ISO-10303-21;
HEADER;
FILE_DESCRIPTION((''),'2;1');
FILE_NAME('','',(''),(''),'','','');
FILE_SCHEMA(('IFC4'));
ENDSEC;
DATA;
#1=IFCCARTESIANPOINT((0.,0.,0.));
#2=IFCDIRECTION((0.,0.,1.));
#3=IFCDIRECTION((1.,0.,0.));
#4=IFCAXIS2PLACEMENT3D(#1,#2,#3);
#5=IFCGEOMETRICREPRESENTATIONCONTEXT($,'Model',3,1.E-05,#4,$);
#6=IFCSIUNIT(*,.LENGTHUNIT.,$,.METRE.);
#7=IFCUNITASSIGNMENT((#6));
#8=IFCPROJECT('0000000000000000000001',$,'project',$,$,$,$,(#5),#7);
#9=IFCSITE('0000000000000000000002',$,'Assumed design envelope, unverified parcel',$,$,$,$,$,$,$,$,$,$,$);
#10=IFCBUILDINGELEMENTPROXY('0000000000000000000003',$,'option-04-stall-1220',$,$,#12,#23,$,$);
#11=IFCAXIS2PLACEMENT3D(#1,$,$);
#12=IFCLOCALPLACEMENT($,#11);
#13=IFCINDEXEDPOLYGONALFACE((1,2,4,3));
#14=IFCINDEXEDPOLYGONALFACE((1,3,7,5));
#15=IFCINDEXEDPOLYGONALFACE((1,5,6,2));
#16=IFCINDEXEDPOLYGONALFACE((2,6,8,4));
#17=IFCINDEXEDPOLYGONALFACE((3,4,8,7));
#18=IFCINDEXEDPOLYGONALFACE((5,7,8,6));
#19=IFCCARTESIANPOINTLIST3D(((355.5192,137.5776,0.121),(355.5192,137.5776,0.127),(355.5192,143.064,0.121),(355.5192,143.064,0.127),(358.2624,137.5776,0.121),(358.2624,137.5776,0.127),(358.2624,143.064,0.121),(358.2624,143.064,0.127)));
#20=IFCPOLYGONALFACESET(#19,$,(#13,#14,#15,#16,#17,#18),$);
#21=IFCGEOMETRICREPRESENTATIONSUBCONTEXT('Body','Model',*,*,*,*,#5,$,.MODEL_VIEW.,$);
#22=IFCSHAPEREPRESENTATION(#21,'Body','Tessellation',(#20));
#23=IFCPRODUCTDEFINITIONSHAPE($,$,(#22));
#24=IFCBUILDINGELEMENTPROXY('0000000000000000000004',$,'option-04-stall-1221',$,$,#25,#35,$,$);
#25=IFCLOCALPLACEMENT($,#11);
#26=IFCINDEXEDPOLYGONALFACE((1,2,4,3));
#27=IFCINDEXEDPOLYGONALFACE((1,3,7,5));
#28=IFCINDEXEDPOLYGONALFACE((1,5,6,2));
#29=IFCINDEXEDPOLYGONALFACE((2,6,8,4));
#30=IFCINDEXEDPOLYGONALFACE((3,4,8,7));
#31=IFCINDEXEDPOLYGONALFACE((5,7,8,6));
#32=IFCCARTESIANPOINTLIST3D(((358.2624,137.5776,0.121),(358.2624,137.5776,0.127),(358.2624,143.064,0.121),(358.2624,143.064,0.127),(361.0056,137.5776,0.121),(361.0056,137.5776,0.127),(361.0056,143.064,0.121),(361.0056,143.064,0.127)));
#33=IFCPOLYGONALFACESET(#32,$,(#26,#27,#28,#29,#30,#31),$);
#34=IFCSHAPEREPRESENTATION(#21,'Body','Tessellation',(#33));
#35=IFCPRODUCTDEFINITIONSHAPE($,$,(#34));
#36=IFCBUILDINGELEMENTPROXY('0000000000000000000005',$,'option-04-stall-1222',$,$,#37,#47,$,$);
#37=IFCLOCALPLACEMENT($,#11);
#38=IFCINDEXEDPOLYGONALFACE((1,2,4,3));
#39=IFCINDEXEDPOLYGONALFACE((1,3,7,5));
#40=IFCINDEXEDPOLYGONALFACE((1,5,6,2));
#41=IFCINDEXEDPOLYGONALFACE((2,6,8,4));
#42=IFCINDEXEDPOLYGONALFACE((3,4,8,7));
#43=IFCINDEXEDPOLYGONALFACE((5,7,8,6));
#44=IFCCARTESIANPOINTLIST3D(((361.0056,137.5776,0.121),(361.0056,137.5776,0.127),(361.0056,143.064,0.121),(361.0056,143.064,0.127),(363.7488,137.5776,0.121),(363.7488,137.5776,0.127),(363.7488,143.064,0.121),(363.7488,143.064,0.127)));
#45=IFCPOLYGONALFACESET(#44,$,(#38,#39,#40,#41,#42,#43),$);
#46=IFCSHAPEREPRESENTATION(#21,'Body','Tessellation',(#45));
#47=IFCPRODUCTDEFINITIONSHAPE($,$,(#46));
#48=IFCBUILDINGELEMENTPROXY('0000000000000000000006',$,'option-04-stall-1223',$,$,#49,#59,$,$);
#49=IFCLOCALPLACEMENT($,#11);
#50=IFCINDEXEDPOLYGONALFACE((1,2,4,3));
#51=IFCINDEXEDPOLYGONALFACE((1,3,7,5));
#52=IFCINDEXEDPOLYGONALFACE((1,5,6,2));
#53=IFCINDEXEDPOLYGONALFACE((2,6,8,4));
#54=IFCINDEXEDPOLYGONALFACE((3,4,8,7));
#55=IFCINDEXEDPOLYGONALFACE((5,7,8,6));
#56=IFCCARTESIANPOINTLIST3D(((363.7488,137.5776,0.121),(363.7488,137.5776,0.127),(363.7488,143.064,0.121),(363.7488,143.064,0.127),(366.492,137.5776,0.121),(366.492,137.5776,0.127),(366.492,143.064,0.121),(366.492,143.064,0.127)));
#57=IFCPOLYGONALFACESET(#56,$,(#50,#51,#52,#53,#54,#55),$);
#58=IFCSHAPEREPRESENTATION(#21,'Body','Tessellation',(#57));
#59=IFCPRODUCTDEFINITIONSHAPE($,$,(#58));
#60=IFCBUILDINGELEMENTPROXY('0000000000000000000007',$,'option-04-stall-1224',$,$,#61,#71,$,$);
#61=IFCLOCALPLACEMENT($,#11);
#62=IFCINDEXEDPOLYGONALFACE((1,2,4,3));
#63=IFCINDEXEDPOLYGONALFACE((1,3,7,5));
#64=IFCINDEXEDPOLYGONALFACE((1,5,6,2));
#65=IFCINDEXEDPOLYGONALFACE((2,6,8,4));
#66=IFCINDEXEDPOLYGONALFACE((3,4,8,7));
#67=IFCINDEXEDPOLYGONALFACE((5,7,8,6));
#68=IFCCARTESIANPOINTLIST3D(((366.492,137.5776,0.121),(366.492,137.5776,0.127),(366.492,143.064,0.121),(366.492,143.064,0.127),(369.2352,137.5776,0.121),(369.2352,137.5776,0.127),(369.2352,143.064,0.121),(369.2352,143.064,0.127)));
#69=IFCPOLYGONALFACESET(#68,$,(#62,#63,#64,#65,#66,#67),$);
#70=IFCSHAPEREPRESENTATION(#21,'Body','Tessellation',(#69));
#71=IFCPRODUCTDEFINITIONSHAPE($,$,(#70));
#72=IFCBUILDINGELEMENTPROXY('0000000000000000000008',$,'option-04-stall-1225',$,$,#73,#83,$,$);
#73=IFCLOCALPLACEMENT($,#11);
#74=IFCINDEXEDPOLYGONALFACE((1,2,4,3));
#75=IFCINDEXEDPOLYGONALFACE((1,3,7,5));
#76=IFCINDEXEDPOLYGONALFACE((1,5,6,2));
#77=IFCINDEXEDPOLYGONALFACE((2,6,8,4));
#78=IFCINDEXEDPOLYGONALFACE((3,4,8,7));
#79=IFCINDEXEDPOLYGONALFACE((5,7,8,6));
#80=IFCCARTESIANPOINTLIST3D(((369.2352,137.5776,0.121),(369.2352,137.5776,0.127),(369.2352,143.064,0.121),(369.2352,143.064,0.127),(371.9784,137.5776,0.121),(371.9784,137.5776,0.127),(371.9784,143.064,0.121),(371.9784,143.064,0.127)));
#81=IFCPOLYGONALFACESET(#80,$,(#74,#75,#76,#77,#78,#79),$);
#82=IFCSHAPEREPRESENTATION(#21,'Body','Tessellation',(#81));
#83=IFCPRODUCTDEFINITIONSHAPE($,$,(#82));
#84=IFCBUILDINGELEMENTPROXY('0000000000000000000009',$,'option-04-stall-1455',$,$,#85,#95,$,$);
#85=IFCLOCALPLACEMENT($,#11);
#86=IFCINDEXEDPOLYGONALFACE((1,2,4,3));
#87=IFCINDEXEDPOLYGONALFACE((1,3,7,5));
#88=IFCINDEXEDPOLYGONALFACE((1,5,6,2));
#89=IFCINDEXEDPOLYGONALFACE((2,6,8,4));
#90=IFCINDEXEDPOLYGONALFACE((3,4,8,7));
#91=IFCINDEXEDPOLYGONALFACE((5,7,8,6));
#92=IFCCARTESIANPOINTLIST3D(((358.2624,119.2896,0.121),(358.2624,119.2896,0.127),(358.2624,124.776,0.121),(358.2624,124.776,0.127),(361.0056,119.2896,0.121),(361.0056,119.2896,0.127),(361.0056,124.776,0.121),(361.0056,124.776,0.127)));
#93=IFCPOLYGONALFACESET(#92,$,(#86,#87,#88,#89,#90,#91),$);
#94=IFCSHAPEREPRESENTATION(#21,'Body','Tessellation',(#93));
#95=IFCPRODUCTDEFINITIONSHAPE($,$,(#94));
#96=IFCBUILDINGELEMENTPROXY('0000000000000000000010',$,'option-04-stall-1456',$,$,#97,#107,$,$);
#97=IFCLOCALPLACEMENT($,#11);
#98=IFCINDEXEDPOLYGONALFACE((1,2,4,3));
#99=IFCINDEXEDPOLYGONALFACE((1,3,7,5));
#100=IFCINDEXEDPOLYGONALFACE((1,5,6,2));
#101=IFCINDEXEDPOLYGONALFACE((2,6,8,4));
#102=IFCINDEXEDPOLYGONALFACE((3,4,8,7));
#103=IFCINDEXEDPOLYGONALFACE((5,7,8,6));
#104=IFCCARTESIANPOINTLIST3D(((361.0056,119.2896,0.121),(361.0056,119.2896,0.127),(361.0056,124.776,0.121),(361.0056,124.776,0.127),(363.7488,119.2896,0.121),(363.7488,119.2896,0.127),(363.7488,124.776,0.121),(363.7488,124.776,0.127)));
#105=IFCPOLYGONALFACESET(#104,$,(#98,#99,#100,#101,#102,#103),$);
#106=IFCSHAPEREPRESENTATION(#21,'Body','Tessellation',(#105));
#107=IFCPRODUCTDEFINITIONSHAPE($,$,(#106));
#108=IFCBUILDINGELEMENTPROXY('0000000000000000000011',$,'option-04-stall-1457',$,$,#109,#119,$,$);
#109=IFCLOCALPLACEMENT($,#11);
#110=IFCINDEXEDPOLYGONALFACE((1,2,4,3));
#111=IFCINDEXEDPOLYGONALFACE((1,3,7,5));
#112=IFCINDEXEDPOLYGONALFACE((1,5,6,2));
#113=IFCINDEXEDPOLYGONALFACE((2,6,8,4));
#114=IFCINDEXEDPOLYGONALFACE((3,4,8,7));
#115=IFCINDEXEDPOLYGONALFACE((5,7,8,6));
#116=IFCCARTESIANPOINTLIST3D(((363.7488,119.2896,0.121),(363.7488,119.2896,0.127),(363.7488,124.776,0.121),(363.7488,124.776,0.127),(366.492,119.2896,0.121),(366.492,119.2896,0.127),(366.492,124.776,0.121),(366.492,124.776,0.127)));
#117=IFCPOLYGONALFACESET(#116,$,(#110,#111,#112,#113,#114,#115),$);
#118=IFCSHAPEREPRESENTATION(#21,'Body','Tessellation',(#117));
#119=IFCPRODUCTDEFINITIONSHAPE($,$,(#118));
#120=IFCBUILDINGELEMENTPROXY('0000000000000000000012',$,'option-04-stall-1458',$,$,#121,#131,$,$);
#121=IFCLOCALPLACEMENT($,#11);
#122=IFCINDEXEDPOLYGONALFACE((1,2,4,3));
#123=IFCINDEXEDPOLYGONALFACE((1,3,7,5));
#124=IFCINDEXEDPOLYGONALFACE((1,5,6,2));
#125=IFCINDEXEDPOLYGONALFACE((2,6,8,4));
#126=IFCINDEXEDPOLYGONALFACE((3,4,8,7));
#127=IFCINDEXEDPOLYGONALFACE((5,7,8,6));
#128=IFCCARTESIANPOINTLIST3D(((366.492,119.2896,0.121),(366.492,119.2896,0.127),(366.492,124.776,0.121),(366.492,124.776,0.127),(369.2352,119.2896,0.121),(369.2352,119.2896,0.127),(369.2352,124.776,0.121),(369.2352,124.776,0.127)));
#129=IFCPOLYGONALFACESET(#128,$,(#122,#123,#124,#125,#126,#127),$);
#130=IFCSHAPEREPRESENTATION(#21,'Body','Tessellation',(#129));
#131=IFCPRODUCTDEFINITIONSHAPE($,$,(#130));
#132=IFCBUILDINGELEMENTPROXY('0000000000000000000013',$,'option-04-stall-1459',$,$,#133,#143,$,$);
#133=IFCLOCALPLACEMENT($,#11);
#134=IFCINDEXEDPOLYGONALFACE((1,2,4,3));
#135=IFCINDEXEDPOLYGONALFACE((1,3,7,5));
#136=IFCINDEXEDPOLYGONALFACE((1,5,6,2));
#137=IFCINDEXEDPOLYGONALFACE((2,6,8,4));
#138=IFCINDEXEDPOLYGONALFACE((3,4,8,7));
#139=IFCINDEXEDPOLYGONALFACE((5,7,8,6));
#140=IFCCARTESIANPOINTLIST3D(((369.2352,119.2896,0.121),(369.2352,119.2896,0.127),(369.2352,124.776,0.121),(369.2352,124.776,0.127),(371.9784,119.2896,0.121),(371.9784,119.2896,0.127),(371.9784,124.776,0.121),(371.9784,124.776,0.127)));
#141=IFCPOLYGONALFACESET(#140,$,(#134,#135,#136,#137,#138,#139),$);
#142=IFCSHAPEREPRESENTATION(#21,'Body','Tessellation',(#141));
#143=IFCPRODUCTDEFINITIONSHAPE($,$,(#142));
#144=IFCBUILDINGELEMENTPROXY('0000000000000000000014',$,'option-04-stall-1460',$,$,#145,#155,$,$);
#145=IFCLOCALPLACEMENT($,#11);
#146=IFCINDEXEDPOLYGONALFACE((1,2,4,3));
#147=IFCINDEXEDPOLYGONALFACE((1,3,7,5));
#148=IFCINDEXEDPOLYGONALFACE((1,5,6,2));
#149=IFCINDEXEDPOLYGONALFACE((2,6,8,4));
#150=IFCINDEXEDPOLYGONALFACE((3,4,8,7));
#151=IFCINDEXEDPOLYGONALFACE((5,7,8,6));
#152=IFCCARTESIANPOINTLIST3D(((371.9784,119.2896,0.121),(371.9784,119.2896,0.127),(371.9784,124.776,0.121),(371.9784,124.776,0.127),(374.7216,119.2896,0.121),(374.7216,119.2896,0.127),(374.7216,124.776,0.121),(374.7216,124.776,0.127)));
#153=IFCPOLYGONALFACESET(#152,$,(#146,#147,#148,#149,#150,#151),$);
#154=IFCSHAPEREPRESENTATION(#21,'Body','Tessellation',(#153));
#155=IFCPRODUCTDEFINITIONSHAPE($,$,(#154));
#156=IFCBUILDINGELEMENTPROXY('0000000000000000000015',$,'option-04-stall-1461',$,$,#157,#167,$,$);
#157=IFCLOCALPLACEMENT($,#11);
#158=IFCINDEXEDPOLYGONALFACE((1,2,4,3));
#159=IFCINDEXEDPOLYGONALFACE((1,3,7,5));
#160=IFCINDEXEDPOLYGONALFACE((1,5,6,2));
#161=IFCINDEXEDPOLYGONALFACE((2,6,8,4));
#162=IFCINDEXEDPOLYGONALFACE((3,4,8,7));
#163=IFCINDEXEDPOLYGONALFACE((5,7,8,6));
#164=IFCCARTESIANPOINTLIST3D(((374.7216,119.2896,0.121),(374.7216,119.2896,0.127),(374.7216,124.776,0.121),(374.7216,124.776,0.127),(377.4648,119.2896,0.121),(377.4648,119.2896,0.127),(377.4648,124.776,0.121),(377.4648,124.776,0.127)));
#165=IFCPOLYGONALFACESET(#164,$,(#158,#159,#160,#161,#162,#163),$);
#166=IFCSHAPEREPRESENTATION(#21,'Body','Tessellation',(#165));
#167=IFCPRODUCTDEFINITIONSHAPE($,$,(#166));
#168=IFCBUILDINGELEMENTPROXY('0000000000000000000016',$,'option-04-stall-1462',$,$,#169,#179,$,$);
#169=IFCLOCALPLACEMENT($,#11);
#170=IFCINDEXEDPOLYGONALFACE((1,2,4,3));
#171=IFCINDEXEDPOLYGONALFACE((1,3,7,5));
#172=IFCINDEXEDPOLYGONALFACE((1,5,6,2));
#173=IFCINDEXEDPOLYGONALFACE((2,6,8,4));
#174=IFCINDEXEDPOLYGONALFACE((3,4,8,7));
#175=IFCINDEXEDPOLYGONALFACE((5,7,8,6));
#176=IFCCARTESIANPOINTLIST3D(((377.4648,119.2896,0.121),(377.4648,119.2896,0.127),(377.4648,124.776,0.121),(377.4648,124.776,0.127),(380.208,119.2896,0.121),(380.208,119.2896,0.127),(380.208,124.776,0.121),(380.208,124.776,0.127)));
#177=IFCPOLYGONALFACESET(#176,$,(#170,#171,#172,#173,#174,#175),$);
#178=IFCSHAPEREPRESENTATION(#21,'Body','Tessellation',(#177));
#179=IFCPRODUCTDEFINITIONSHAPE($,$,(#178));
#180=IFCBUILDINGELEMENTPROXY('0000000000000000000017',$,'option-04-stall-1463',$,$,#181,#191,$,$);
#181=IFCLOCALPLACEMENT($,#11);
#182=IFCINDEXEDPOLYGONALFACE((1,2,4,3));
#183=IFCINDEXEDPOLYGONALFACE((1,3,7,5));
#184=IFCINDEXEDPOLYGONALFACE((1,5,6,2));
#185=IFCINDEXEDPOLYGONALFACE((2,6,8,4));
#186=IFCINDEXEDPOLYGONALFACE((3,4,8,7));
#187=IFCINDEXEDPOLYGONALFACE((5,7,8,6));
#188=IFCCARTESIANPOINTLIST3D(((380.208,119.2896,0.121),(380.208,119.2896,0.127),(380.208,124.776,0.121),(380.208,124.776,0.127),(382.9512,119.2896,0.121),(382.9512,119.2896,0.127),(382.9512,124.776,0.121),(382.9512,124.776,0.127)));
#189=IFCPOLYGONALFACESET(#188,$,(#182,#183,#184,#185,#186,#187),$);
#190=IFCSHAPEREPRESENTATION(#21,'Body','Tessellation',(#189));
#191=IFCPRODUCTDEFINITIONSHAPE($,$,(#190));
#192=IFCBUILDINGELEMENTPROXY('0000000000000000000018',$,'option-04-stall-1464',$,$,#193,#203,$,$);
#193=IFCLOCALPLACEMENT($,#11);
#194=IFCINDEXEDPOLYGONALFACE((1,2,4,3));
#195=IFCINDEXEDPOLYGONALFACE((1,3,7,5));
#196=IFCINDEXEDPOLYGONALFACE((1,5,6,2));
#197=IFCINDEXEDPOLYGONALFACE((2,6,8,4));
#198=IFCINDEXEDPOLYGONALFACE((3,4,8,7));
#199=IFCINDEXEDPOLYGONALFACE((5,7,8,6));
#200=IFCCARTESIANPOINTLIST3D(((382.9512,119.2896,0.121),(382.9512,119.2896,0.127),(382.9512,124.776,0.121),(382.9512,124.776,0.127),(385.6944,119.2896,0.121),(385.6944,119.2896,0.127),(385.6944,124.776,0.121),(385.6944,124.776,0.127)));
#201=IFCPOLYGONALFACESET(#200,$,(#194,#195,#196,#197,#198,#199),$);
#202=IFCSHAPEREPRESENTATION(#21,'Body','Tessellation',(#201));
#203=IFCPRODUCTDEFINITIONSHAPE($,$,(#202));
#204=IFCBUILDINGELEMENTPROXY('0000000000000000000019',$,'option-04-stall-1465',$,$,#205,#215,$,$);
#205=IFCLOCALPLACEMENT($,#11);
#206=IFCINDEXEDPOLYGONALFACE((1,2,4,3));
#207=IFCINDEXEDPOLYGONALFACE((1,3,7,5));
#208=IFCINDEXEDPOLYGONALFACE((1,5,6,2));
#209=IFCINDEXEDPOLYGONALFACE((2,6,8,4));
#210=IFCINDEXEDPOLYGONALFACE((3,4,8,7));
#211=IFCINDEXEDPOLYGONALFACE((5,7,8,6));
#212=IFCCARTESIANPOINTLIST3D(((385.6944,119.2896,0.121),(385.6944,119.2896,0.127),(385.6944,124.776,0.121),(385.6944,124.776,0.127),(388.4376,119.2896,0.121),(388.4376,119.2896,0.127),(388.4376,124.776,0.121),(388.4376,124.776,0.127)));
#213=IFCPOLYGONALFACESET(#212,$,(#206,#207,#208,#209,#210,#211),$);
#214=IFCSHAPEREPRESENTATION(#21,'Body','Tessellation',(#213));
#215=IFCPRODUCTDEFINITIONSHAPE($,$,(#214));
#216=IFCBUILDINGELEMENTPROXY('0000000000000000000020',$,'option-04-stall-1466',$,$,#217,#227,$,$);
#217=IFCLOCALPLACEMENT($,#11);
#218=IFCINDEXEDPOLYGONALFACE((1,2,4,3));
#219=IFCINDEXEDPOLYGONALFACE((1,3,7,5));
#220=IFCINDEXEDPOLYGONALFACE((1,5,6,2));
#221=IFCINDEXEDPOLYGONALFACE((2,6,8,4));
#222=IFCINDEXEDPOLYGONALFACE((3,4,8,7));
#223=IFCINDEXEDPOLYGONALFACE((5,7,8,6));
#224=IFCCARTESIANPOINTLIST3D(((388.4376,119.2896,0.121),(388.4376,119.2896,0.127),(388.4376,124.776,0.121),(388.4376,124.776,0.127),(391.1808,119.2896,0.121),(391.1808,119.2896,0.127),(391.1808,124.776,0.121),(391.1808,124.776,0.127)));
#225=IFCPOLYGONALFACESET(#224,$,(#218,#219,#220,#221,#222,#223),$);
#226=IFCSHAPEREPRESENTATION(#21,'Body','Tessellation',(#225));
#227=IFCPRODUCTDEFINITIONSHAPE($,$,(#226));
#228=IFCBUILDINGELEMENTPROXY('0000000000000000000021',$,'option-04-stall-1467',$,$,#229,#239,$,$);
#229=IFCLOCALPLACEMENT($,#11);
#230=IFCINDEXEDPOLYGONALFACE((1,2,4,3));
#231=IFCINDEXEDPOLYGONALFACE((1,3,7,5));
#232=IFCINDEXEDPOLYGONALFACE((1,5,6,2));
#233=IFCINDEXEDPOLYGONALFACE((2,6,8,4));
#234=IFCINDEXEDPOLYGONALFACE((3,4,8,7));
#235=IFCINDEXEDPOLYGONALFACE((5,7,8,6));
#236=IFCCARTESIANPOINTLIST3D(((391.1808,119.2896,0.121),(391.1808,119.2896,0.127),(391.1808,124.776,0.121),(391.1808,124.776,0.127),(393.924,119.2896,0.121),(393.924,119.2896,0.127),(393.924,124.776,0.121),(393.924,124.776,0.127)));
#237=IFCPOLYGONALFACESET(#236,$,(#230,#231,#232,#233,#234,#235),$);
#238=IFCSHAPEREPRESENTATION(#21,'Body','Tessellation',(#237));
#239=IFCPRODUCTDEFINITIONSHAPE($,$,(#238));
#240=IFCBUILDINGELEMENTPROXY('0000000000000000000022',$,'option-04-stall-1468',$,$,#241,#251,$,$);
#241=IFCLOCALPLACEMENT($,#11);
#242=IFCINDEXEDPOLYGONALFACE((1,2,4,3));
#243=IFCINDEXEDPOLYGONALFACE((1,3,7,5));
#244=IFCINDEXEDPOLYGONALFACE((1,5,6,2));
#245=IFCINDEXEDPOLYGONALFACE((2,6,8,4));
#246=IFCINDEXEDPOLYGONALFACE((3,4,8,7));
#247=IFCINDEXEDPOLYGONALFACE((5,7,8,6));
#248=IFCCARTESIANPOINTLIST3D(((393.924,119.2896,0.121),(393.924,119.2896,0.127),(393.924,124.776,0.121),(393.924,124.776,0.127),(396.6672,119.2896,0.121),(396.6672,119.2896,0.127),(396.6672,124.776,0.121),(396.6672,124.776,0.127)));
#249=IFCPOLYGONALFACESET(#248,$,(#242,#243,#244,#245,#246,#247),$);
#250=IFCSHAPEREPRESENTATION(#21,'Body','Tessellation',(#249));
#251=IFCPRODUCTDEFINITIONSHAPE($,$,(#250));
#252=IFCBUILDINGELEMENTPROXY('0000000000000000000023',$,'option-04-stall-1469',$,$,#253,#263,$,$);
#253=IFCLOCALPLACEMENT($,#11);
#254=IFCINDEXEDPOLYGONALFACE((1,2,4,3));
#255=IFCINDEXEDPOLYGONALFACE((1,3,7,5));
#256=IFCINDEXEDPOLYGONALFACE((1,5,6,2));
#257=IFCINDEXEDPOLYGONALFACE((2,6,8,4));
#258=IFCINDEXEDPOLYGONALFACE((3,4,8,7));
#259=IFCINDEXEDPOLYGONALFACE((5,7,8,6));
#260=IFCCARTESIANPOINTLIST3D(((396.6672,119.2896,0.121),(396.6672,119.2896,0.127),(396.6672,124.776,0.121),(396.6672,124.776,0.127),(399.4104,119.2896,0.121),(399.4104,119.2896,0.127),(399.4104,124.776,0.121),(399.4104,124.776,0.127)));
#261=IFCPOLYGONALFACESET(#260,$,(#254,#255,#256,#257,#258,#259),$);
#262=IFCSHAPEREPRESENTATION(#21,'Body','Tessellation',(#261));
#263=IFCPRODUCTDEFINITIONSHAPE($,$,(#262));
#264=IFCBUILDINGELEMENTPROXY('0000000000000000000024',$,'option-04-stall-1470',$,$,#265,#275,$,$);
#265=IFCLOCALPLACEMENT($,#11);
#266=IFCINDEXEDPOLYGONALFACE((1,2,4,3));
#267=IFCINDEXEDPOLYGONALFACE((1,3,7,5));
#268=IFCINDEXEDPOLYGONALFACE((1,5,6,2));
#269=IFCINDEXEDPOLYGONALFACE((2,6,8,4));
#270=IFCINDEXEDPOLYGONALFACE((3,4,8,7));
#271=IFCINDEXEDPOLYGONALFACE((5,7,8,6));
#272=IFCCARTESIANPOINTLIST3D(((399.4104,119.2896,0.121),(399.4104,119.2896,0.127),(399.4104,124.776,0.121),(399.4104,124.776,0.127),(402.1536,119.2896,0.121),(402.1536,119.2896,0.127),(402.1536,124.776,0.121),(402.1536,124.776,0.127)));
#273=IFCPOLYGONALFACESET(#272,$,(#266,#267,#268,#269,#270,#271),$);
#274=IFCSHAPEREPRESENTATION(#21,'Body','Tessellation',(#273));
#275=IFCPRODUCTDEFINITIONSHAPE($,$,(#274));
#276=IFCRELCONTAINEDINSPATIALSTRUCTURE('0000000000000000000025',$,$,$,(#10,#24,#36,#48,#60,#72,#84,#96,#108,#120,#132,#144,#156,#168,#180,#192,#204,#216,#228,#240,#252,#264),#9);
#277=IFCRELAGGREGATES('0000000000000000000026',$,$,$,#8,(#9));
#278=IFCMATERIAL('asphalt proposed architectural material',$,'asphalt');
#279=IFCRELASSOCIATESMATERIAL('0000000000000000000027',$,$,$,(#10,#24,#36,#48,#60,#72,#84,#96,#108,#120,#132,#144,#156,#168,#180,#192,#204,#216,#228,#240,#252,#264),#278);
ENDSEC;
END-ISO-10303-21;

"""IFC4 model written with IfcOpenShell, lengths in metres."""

from ifc_helpers import new_model, si_unit, frame, origin_with_axes, place, context, subcontext, project, spatial, rectangle, extrude, material, element, save


model = new_model("IFC4")

# Units and contexts
model_context = context("Model", 3, precision=1e-05, world=origin_with_axes())
body_context = subcontext(model_context, "Body", "Model", "MODEL_VIEW")
ifc_project = project(units=[si_unit("LENGTHUNIT", "METRE")], contexts=[model_context])

# Site
site = spatial("IfcSite", under=ifc_project, Name="Assumed design envelope, unverified parcel")

# Building element proxies
ifc_material = material(Name="asphalt proposed architectural material", Category="asphalt")
for number, where, z_axis, x_axis, name in (
    (1, (356.8908, 140.3208, 0.121), (0.0, 0.0, 1.0), (1.0, 0.0, 0.0), "option-04-stall-1220"),
    (2, (359.634, 140.3208, 0.121), (0.0, 0.0, 1.0), (1.0, 0.0, 0.0), "option-04-stall-1221"),
    (3, (362.3772, 140.3208, 0.121), (0.0, 0.0, 1.0), (1.0, 0.0, 0.0), "option-04-stall-1222"),
    (4, (365.1204, 140.3208, 0.121), (0.0, 0.0, 1.0), (1.0, 0.0, 0.0), "option-04-stall-1223"),
    (5, (367.8636, 140.3208, 0.121), (0.0, 0.0, 1.0), (1.0, 0.0, 0.0), "option-04-stall-1224"),
    (6, (370.6068, 140.3208, 0.121), (0.0, 0.0, 1.0), (1.0, 0.0, 0.0), "option-04-stall-1225"),
    (7, (359.634, 122.0328, 0.121), (0.0, 0.0, 1.0), (1.0, 0.0, 0.0), "option-04-stall-1455"),
    (8, (362.3772, 122.0328, 0.121), (0.0, 0.0, 1.0), (1.0, 0.0, 0.0), "option-04-stall-1456"),
    (9, (365.1204, 122.0328, 0.121), (0.0, 0.0, 1.0), (1.0, 0.0, 0.0), "option-04-stall-1457"),
    (10, (367.8636, 122.0328, 0.121), (0.0, 0.0, 1.0), (1.0, 0.0, 0.0), "option-04-stall-1458"),
    (11, (370.6068, 122.0328, 0.121), (0.0, 0.0, 1.0), (1.0, 0.0, 0.0), "option-04-stall-1459"),
    (12, (373.35, 122.0328, 0.121), (0.0, 0.0, 1.0), (1.0, 0.0, 0.0), "option-04-stall-1460"),
    (13, (376.0932, 122.0328, 0.121), (0.0, 0.0, 1.0), (1.0, 0.0, 0.0), "option-04-stall-1461"),
    (14, (378.8364, 122.0328, 0.121), (0.0, 0.0, 1.0), (1.0, 0.0, 0.0), "option-04-stall-1462"),
    (15, (381.5796, 122.0328, 0.121), (0.0, 0.0, 1.0), (1.0, 0.0, 0.0), "option-04-stall-1463"),
    (16, (384.3228, 122.0328, 0.121), (0.0, 0.0, 1.0), (1.0, 0.0, 0.0), "option-04-stall-1464"),
    (17, (387.066, 122.0328, 0.121), (0.0, 0.0, 1.0), (1.0, 0.0, 0.0), "option-04-stall-1465"),
    (18, (389.8092, 122.0328, 0.121), (0.0, 0.0, 1.0), (1.0, 0.0, 0.0), "option-04-stall-1466"),
    (19, (392.5524, 122.0328, 0.121), (0.0, 0.0, 1.0), (1.0, 0.0, 0.0), "option-04-stall-1467"),
    (20, (395.2956, 122.0328, 0.121), (0.0, 0.0, 1.0), (1.0, 0.0, 0.0), "option-04-stall-1468"),
    (21, (398.0388, 122.0328, 0.121), (0.0, 0.0, 1.0), (1.0, 0.0, 0.0), "option-04-stall-1469"),
    (22, (400.782, 122.0328, 0.121), (0.0, 0.0, 1.0), (1.0, 0.0, 0.0), "option-04-stall-1470"),
):
    element("IfcBuildingElementProxy", number, at=place(None, frame(where, z_axis=z_axis, x_axis=x_axis)), inside=site, material=ifc_material, Name=name, context=body_context, shape_type="SweptSolid", body=[
        extrude(rectangle(XDim=2.7432, YDim=5.4864), origin_with_axes(), (0.0, 0.0, 1.0), 0.006),
    ])

save(model, "model.ifc")
